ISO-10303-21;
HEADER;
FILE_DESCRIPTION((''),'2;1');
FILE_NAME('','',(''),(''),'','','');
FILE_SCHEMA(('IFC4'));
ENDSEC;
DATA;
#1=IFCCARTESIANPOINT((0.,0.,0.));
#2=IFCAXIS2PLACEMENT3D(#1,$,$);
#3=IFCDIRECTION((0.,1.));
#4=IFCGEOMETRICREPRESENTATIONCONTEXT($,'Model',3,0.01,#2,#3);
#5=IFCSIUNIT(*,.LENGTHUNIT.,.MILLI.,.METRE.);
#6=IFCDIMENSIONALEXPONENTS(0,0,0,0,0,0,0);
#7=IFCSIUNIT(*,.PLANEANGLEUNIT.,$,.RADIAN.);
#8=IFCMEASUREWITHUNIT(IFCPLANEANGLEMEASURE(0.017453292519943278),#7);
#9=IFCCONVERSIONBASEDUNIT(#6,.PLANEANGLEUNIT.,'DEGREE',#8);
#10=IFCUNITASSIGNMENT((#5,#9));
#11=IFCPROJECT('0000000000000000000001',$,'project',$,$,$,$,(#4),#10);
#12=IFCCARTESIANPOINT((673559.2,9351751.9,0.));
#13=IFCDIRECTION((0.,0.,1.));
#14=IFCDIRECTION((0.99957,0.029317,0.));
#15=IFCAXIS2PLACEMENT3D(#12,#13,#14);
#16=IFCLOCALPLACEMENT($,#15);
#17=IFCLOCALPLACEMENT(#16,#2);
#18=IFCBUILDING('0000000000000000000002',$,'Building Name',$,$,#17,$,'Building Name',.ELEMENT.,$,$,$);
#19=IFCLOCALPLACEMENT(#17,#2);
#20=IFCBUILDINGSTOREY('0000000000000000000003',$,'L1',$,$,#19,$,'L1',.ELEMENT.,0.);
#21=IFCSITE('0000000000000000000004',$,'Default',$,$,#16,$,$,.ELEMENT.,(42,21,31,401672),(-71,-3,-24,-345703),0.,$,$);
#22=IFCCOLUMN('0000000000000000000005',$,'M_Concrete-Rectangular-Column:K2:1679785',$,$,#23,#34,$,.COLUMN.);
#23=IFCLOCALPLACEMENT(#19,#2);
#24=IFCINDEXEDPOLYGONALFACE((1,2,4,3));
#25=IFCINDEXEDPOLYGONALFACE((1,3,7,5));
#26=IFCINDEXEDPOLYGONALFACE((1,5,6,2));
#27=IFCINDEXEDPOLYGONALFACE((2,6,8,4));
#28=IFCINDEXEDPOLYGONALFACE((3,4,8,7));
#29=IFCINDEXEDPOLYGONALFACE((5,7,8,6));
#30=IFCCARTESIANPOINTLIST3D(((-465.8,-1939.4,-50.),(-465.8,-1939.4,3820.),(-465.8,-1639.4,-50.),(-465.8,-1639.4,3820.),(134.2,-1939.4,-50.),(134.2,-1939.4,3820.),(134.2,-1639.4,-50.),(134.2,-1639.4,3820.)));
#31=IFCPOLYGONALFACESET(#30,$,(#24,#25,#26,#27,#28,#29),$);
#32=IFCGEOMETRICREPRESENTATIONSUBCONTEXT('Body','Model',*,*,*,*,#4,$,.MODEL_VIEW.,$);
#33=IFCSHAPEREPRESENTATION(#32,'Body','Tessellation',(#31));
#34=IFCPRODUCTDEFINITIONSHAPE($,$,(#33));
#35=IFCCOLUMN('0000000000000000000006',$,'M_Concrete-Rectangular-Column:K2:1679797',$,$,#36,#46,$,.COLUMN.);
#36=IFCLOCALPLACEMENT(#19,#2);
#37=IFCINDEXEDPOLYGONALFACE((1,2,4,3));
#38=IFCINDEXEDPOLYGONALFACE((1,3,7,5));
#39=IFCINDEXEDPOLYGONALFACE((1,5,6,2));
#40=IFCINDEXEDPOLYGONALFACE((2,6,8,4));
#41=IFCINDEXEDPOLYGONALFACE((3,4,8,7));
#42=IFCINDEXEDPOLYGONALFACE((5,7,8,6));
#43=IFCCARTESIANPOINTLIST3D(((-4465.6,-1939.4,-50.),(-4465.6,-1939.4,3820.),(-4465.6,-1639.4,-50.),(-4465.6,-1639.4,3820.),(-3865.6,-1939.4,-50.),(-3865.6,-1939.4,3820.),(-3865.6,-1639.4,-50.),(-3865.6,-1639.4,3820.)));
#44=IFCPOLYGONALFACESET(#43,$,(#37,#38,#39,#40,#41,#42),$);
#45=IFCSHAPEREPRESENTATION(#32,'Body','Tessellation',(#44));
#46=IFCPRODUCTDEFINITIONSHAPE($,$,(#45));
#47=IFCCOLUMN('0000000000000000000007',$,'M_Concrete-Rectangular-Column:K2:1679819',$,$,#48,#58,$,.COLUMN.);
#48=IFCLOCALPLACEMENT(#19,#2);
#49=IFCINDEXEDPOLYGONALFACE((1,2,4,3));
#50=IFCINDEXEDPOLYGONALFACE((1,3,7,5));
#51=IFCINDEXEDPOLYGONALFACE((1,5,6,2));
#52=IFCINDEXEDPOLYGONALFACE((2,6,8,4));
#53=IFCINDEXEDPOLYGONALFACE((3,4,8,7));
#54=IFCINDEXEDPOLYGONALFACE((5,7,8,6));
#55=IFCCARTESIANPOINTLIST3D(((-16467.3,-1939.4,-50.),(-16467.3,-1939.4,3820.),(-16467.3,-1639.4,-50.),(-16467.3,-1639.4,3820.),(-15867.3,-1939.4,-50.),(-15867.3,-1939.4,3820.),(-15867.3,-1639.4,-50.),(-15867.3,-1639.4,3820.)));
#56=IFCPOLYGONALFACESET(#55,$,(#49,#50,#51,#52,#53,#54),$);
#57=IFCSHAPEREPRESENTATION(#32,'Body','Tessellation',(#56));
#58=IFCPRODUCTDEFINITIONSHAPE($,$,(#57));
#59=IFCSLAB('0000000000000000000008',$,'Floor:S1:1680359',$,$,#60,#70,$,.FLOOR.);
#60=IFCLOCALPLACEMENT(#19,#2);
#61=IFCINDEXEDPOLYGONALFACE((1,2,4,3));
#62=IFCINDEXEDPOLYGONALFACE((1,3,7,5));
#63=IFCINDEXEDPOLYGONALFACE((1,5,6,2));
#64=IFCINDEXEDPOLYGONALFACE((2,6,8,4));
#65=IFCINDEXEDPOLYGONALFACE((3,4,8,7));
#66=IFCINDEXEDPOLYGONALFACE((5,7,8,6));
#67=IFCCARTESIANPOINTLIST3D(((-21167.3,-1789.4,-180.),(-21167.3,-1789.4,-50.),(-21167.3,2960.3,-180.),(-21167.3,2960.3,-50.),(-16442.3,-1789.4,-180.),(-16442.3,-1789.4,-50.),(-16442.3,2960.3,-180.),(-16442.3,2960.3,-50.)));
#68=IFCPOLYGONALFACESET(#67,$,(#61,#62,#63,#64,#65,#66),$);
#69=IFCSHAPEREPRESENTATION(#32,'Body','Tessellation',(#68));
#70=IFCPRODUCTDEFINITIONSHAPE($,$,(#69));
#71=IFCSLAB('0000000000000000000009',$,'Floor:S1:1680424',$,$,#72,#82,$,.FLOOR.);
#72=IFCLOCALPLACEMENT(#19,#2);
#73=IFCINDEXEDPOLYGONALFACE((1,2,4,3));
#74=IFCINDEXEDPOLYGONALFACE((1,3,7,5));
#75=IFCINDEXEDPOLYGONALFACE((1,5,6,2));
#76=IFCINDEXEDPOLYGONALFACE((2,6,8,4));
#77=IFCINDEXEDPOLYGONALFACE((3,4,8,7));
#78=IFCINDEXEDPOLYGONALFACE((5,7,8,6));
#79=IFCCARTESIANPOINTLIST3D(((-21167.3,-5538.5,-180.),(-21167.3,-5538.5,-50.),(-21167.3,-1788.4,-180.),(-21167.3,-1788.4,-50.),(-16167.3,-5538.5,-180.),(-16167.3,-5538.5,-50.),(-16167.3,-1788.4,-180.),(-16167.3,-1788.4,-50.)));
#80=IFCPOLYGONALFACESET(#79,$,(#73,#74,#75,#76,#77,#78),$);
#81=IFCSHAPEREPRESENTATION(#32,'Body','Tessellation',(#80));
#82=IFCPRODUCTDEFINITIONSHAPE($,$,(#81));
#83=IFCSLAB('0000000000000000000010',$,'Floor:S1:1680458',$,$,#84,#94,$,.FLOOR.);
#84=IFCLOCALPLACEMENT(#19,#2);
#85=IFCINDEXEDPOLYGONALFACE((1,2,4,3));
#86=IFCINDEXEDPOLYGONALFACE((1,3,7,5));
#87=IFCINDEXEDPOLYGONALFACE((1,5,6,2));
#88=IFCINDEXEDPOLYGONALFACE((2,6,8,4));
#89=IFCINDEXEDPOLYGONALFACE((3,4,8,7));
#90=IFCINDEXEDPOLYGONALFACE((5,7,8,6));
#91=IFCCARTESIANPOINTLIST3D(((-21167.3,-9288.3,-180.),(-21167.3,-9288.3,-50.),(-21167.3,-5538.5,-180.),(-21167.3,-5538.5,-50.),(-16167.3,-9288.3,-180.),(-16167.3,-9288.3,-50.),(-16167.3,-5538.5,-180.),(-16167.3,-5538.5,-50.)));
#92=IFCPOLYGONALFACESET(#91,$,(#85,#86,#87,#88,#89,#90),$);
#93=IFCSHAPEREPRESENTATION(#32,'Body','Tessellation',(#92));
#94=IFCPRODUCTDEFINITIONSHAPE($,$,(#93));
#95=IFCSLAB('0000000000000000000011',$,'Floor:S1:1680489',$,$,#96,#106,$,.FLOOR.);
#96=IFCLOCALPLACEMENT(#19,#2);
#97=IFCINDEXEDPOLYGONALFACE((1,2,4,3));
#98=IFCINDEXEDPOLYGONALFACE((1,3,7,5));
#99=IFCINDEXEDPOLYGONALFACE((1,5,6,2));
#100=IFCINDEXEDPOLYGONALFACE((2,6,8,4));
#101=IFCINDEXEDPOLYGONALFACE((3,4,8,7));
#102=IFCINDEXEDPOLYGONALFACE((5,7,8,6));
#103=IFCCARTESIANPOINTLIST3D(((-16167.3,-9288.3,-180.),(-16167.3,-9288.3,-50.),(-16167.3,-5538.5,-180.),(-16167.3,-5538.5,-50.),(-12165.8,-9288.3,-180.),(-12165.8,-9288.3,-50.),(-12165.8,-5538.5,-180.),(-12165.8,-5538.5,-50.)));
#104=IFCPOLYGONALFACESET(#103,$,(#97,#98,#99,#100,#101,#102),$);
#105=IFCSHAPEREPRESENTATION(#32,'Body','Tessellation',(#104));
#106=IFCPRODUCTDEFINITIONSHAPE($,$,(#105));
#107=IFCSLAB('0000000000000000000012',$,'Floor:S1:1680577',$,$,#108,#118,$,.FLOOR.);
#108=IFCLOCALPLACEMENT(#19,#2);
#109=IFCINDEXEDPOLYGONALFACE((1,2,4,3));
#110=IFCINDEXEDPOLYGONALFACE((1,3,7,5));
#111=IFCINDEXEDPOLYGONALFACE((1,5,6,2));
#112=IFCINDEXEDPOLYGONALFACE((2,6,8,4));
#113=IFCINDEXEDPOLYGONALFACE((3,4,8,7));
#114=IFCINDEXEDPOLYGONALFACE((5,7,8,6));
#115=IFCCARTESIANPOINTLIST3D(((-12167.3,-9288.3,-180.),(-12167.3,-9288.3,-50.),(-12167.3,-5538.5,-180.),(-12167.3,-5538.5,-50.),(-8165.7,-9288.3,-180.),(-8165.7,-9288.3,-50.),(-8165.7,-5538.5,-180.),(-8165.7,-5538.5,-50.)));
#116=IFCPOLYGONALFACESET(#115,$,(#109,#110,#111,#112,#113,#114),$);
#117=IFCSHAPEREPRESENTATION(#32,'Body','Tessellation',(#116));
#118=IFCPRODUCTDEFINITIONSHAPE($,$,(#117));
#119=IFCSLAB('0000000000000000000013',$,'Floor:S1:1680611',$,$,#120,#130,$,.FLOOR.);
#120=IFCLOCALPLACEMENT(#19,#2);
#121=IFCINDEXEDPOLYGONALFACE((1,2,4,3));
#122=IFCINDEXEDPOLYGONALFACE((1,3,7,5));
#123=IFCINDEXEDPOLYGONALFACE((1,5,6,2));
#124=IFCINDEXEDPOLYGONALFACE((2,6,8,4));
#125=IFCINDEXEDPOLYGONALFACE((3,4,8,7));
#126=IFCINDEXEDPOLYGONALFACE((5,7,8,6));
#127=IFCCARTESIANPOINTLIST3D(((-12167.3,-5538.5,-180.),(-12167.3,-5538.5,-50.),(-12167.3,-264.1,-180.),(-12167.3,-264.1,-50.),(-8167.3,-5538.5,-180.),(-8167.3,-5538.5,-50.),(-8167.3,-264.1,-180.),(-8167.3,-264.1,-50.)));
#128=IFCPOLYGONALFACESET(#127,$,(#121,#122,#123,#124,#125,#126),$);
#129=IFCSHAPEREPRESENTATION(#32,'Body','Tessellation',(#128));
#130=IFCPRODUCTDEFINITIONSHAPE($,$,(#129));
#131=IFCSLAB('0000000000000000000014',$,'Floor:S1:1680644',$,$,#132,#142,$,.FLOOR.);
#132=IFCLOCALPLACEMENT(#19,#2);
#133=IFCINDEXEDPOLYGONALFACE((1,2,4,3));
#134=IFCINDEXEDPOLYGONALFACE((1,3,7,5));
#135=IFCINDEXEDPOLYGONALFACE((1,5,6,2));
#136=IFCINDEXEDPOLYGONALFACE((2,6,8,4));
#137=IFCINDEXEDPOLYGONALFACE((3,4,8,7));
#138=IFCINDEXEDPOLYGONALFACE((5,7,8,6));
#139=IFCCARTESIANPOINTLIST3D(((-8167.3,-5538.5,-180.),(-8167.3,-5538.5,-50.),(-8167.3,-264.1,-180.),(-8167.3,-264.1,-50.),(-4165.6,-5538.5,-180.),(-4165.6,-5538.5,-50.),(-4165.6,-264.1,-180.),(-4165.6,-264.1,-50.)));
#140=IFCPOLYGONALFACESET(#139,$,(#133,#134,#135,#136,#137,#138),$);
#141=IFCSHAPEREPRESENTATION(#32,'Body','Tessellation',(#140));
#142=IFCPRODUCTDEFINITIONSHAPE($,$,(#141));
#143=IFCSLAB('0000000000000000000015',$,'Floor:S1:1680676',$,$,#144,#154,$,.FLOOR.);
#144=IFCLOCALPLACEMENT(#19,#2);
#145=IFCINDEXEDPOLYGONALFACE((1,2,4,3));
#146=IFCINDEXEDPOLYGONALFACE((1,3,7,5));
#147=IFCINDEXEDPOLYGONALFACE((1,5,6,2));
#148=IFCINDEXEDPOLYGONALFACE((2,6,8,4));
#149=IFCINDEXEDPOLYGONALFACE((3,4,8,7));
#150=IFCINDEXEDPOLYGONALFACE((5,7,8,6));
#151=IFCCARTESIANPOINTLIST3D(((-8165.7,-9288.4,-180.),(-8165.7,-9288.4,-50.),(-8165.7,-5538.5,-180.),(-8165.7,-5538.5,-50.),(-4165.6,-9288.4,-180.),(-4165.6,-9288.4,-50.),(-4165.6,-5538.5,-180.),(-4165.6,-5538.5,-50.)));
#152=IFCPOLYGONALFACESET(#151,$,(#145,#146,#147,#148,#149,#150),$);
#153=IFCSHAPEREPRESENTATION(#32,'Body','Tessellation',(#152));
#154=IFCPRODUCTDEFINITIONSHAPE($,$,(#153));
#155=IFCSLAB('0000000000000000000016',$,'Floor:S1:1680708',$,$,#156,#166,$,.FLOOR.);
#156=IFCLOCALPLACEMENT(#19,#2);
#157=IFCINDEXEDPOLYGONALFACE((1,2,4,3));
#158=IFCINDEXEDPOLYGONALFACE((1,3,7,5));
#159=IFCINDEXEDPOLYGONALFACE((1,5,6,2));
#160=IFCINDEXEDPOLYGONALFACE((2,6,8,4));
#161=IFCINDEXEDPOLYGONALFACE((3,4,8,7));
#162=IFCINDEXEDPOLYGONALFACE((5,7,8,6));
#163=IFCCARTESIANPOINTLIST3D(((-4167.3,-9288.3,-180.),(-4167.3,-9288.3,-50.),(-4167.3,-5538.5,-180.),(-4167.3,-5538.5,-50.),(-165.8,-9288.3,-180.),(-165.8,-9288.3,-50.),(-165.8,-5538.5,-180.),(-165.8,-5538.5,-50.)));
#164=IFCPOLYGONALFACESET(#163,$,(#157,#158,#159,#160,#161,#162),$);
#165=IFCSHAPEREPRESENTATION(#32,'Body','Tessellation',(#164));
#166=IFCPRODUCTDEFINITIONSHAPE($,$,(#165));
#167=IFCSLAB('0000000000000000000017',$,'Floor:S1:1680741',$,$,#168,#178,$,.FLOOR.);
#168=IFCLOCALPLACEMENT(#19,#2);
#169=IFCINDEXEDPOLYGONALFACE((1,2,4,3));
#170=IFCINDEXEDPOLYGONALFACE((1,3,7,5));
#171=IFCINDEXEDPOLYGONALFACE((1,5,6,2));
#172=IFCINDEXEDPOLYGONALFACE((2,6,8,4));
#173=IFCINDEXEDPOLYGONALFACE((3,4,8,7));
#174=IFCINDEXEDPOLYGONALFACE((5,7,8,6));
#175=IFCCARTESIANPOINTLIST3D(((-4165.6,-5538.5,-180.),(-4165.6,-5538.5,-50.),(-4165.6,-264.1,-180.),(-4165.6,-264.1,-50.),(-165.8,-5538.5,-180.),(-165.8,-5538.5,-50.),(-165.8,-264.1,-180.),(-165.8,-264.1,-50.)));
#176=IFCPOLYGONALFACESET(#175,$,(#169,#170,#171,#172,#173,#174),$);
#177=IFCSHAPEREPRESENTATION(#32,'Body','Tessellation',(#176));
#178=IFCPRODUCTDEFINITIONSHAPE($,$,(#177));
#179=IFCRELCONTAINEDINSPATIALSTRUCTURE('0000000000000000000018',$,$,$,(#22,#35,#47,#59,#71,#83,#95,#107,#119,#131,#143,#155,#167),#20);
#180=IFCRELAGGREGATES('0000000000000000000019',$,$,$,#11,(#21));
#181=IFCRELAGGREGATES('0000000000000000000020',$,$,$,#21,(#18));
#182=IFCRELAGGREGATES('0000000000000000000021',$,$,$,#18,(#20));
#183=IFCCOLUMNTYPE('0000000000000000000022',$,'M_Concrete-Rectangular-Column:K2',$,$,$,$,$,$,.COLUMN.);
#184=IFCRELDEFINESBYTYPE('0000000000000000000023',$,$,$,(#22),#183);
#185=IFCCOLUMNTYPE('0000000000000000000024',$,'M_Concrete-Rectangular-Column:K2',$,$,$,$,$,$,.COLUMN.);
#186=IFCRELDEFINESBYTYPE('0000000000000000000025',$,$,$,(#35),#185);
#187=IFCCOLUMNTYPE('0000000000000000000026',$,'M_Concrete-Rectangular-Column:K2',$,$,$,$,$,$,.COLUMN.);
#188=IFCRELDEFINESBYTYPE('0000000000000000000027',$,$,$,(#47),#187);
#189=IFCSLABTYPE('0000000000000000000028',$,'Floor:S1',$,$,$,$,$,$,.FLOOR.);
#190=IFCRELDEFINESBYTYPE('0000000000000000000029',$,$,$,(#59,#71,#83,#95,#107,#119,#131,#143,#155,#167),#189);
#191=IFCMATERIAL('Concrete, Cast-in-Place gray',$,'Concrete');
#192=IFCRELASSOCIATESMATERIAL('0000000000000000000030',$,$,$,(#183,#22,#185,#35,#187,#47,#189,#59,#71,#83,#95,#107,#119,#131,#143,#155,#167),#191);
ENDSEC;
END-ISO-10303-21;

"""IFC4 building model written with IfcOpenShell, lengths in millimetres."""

from ifc_helpers import new_model, entity, si_unit, converted_unit, direction, frame, origin, place, context, subcontext, project, spatial, indexed_curve, outline, extrude, source, transform, mapped, material, type_object, type_shapes, element, save


model = new_model("IFC4")

# Units and contexts
model_context = context("Model", 3, precision=0.01, world=origin(), true_north=direction((0.0, 1.0)))
body_context = subcontext(model_context, "Body", "Model", "MODEL_VIEW")
ifc_project = project(units=[si_unit("LENGTHUNIT", "METRE", prefix="MILLI"), converted_unit("PLANEANGLEUNIT", "DEGREE", entity("IfcPlaneAngleMeasure", 0.017453292519943278), si_unit("PLANEANGLEUNIT", "RADIAN"), dimensions=[0, 0, 0, 0, 0, 0, 0])], contexts=[model_context])

# Site, building, storey
site_placement = place(None, frame((673559.2, 9351751.9, 0.0), z_axis=(0.0, 0.0, 1.0), x_axis=(0.99957, 0.029317, 0.0)))
site = spatial("IfcSite", under=ifc_project, at=site_placement, Name="Default", CompositionType="ELEMENT", RefLatitude=(42, 21, 31, 401672), RefLongitude=(-71, -3, -24, -345703), RefElevation=0.0)
building_placement = place(site_placement, origin())
building = spatial("IfcBuilding", under=site, at=building_placement, Name="Building Name", LongName="Building Name", CompositionType="ELEMENT")
storey_placement = place(building_placement, origin())
storey = spatial("IfcBuildingStorey", under=building, at=storey_placement, Name="L1", LongName="L1", CompositionType="ELEMENT", Elevation=0.0)

# Columns
ifc_material = material(Name="Concrete, Cast-in-Place gray", Category="Concrete")
column_type_1 = type_object("IfcColumnType", Name="M_Concrete-Rectangular-Column:K2", PredefinedType="COLUMN", material=ifc_material)
shared_shape_1 = source(origin(), body_context, "Body", "SweptSolid", [
    extrude(outline(indexed_curve([(-150.0, -300.0), (150.0, -300.0), (150.0, 300.0), (-150.0, 300.0), (-150.0, -300.0)], self_intersect=False)), frame((-165.8, -1789.4, -50.0), z_axis=(0.0, 0.0, 1.0), x_axis=(0.0, -1.0, 0.0)), (0.0, 0.0, 1.0), 3870.0),
])
type_shapes(column_type_1, [shared_shape_1])
column_1_placement = place(storey_placement, origin())
element("IfcColumn", 1, at=column_1_placement, inside=storey, type_object=column_type_1, material=ifc_material, Name="M_Concrete-Rectangular-Column:K2:1679785", PredefinedType="COLUMN", context=body_context, shape_type="MappedRepresentation", body=[
    mapped(shared_shape_1, transform((0.0, 0.0, 0.0), scale=1.0)),
])
column_type_2 = type_object("IfcColumnType", Name="M_Concrete-Rectangular-Column:K2", PredefinedType="COLUMN", material=ifc_material)
shared_shape_2 = source(origin(), body_context, "Body", "SweptSolid", [
    extrude(outline(indexed_curve([(-150.0, -300.0), (150.0, -300.0), (150.0, 300.0), (-150.0, 300.0), (-150.0, -300.0)], self_intersect=False)), frame((-4165.6, -1789.4, -50.0), z_axis=(0.0, 0.0, 1.0), x_axis=(0.0, -1.0, 0.0)), (0.0, 0.0, 1.0), 3870.0),
])
type_shapes(column_type_2, [shared_shape_2])
column_2_placement = place(storey_placement, origin())
element("IfcColumn", 2, at=column_2_placement, inside=storey, type_object=column_type_2, material=ifc_material, Name="M_Concrete-Rectangular-Column:K2:1679797", PredefinedType="COLUMN", context=body_context, shape_type="MappedRepresentation", body=[
    mapped(shared_shape_2, transform((0.0, 0.0, 0.0), scale=1.0)),
])
column_type_3 = type_object("IfcColumnType", Name="M_Concrete-Rectangular-Column:K2", PredefinedType="COLUMN", material=ifc_material)
shared_shape_3 = source(origin(), body_context, "Body", "SweptSolid", [
    extrude(outline(indexed_curve([(-150.0, -300.0), (150.0, -300.0), (150.0, 300.0), (-150.0, 300.0), (-150.0, -300.0)], self_intersect=False)), frame((-16167.3, -1789.4, -50.0), z_axis=(0.0, 0.0, 1.0), x_axis=(0.0, -1.0, 0.0)), (0.0, 0.0, 1.0), 3870.0),
])
type_shapes(column_type_3, [shared_shape_3])
column_3_placement = place(storey_placement, origin())
element("IfcColumn", 3, at=column_3_placement, inside=storey, type_object=column_type_3, material=ifc_material, Name="M_Concrete-Rectangular-Column:K2:1679819", PredefinedType="COLUMN", context=body_context, shape_type="MappedRepresentation", body=[
    mapped(shared_shape_3, transform((0.0, 0.0, 0.0), scale=1.0)),
])

# Slabs
slab_type = type_object("IfcSlabType", Name="Floor:S1", PredefinedType="FLOOR", material=ifc_material)
slab_1_placement = place(storey_placement, origin())
element("IfcSlab", 4, at=slab_1_placement, inside=storey, type_object=slab_type, material=ifc_material, Name="Floor:S1:1680359", PredefinedType="FLOOR", context=body_context, shape_type="SweptSolid", body=[
    extrude(outline(indexed_curve([(-2374.9, -2362.5), (2374.9, -2362.5), (2374.9, 2362.5), (-2374.9, 2362.5), (-2374.9, -2362.5)], self_intersect=False)), frame((-18804.8, 585.4, -50.0), z_axis=(0.0, 0.0, -1.0), x_axis=(0.0, 1.0, 0.0)), (0.0, 0.0, 1.0), 130.0),
])
slab_2_placement = place(storey_placement, origin())
element("IfcSlab", 5, at=slab_2_placement, inside=storey, type_object=slab_type, material=ifc_material, Name="Floor:S1:1680424", PredefinedType="FLOOR", context=body_context, shape_type="SweptSolid", body=[
    extrude(outline(indexed_curve([(-1875.1, -2500.0), (1875.1, -2500.0), (1875.1, 2500.0), (-1875.1, 2500.0), (-1875.1, -2500.0)], self_intersect=False)), frame((-18667.3, -3663.5, -50.0), z_axis=(0.0, 0.0, -1.0), x_axis=(0.0, 1.0, 0.0)), (0.0, 0.0, 1.0), 130.0),
])
slab_3_placement = place(storey_placement, origin())
element("IfcSlab", 6, at=slab_3_placement, inside=storey, type_object=slab_type, material=ifc_material, Name="Floor:S1:1680458", PredefinedType="FLOOR", context=body_context, shape_type="SweptSolid", body=[
    extrude(outline(indexed_curve([(-1874.9, -2500.0), (1874.9, -2500.0), (1874.9, 2500.0), (-1874.9, 2500.0), (-1874.9, -2500.0)], self_intersect=False)), frame((-18667.3, -7413.4, -50.0), z_axis=(0.0, 0.0, -1.0), x_axis=(0.0, 1.0, 0.0)), (0.0, 0.0, 1.0), 130.0),
])
slab_4_placement = place(storey_placement, origin())
element("IfcSlab", 7, at=slab_4_placement, inside=storey, type_object=slab_type, material=ifc_material, Name="Floor:S1:1680489", PredefinedType="FLOOR", context=body_context, shape_type="SweptSolid", body=[
    extrude(outline(indexed_curve([(-1874.9, -2000.8), (1874.9, -2000.8), (1874.9, 2000.8), (-1874.9, 2000.8), (-1874.9, -2000.8)], self_intersect=False)), frame((-14166.6, -7413.4, -50.0), z_axis=(0.0, 0.0, -1.0), x_axis=(0.0, 1.0, 0.0)), (0.0, 0.0, 1.0), 130.0),
])
slab_5_placement = place(storey_placement, origin())
element("IfcSlab", 8, at=slab_5_placement, inside=storey, type_object=slab_type, material=ifc_material, Name="Floor:S1:1680577", PredefinedType="FLOOR", context=body_context, shape_type="SweptSolid", body=[
    extrude(outline(indexed_curve([(-1874.9, -2000.8), (1874.9, -2000.8), (1874.9, 2000.8), (-1874.9, 2000.8), (-1874.9, -2000.8)], self_intersect=False)), frame((-10166.5, -7413.4, -50.0), z_axis=(0.0, 0.0, -1.0), x_axis=(0.0, 1.0, 0.0)), (0.0, 0.0, 1.0), 130.0),
])
slab_6_placement = place(storey_placement, origin())
element("IfcSlab", 9, at=slab_6_placement, inside=storey, type_object=slab_type, material=ifc_material, Name="Floor:S1:1680611", PredefinedType="FLOOR", context=body_context, shape_type="SweptSolid", body=[
    extrude(outline(indexed_curve([(-2637.2, -2000.0), (2637.2, -2000.0), (2637.2, 2000.0), (-2637.2, 2000.0), (-2637.2, -2000.0)], self_intersect=False)), frame((-10167.3, -2901.3, -50.0), z_axis=(0.0, 0.0, -1.0), x_axis=(0.0, 1.0, 0.0)), (0.0, 0.0, 1.0), 130.0),
])
slab_7_placement = place(storey_placement, origin())
element("IfcSlab", 10, at=slab_7_placement, inside=storey, type_object=slab_type, material=ifc_material, Name="Floor:S1:1680644", PredefinedType="FLOOR", context=body_context, shape_type="SweptSolid", body=[
    extrude(outline(indexed_curve([(-2637.2, -2000.9), (2637.2, -2000.9), (2637.2, 2000.9), (-2637.2, 2000.9), (-2637.2, -2000.9)], self_intersect=False)), frame((-6166.4, -2901.3, -50.0), z_axis=(0.0, 0.0, -1.0), x_axis=(0.0, 1.0, 0.0)), (0.0, 0.0, 1.0), 130.0),
])
slab_8_placement = place(storey_placement, origin())
element("IfcSlab", 11, at=slab_8_placement, inside=storey, type_object=slab_type, material=ifc_material, Name="Floor:S1:1680676", PredefinedType="FLOOR", context=body_context, shape_type="SweptSolid", body=[
    extrude(outline(indexed_curve([(-1874.9, -2000.1), (1874.9, -2000.1), (1874.9, 2000.1), (-1874.9, 2000.1), (-1874.9, -2000.1)], self_intersect=False)), frame((-6165.6, -7413.5, -50.0), z_axis=(0.0, 0.0, -1.0), x_axis=(0.0, 1.0, 0.0)), (0.0, 0.0, 1.0), 130.0),
])
slab_9_placement = place(storey_placement, origin())
element("IfcSlab", 12, at=slab_9_placement, inside=storey, type_object=slab_type, material=ifc_material, Name="Floor:S1:1680708", PredefinedType="FLOOR", context=body_context, shape_type="SweptSolid", body=[
    extrude(outline(indexed_curve([(-1874.9, -2000.8), (1874.9, -2000.8), (1874.9, 2000.8), (-1874.9, 2000.8), (-1874.9, -2000.8)], self_intersect=False)), frame((-2166.6, -7413.4, -50.0), z_axis=(0.0, 0.0, -1.0), x_axis=(0.0, 1.0, 0.0)), (0.0, 0.0, 1.0), 130.0),
])
slab_10_placement = place(storey_placement, origin())
element("IfcSlab", 13, at=slab_10_placement, inside=storey, type_object=slab_type, material=ifc_material, Name="Floor:S1:1680741", PredefinedType="FLOOR", context=body_context, shape_type="SweptSolid", body=[
    extrude(outline(indexed_curve([(-2637.2, -1999.9), (2637.2, -1999.9), (2637.2, 1999.9), (-2637.2, 1999.9), (-2637.2, -1999.9)], self_intersect=False)), frame((-2165.7, -2901.3, -50.0), z_axis=(0.0, 0.0, -1.0), x_axis=(0.0, 1.0, 0.0)), (0.0, 0.0, 1.0), 130.0),
])

save(model, "model.ifc")
